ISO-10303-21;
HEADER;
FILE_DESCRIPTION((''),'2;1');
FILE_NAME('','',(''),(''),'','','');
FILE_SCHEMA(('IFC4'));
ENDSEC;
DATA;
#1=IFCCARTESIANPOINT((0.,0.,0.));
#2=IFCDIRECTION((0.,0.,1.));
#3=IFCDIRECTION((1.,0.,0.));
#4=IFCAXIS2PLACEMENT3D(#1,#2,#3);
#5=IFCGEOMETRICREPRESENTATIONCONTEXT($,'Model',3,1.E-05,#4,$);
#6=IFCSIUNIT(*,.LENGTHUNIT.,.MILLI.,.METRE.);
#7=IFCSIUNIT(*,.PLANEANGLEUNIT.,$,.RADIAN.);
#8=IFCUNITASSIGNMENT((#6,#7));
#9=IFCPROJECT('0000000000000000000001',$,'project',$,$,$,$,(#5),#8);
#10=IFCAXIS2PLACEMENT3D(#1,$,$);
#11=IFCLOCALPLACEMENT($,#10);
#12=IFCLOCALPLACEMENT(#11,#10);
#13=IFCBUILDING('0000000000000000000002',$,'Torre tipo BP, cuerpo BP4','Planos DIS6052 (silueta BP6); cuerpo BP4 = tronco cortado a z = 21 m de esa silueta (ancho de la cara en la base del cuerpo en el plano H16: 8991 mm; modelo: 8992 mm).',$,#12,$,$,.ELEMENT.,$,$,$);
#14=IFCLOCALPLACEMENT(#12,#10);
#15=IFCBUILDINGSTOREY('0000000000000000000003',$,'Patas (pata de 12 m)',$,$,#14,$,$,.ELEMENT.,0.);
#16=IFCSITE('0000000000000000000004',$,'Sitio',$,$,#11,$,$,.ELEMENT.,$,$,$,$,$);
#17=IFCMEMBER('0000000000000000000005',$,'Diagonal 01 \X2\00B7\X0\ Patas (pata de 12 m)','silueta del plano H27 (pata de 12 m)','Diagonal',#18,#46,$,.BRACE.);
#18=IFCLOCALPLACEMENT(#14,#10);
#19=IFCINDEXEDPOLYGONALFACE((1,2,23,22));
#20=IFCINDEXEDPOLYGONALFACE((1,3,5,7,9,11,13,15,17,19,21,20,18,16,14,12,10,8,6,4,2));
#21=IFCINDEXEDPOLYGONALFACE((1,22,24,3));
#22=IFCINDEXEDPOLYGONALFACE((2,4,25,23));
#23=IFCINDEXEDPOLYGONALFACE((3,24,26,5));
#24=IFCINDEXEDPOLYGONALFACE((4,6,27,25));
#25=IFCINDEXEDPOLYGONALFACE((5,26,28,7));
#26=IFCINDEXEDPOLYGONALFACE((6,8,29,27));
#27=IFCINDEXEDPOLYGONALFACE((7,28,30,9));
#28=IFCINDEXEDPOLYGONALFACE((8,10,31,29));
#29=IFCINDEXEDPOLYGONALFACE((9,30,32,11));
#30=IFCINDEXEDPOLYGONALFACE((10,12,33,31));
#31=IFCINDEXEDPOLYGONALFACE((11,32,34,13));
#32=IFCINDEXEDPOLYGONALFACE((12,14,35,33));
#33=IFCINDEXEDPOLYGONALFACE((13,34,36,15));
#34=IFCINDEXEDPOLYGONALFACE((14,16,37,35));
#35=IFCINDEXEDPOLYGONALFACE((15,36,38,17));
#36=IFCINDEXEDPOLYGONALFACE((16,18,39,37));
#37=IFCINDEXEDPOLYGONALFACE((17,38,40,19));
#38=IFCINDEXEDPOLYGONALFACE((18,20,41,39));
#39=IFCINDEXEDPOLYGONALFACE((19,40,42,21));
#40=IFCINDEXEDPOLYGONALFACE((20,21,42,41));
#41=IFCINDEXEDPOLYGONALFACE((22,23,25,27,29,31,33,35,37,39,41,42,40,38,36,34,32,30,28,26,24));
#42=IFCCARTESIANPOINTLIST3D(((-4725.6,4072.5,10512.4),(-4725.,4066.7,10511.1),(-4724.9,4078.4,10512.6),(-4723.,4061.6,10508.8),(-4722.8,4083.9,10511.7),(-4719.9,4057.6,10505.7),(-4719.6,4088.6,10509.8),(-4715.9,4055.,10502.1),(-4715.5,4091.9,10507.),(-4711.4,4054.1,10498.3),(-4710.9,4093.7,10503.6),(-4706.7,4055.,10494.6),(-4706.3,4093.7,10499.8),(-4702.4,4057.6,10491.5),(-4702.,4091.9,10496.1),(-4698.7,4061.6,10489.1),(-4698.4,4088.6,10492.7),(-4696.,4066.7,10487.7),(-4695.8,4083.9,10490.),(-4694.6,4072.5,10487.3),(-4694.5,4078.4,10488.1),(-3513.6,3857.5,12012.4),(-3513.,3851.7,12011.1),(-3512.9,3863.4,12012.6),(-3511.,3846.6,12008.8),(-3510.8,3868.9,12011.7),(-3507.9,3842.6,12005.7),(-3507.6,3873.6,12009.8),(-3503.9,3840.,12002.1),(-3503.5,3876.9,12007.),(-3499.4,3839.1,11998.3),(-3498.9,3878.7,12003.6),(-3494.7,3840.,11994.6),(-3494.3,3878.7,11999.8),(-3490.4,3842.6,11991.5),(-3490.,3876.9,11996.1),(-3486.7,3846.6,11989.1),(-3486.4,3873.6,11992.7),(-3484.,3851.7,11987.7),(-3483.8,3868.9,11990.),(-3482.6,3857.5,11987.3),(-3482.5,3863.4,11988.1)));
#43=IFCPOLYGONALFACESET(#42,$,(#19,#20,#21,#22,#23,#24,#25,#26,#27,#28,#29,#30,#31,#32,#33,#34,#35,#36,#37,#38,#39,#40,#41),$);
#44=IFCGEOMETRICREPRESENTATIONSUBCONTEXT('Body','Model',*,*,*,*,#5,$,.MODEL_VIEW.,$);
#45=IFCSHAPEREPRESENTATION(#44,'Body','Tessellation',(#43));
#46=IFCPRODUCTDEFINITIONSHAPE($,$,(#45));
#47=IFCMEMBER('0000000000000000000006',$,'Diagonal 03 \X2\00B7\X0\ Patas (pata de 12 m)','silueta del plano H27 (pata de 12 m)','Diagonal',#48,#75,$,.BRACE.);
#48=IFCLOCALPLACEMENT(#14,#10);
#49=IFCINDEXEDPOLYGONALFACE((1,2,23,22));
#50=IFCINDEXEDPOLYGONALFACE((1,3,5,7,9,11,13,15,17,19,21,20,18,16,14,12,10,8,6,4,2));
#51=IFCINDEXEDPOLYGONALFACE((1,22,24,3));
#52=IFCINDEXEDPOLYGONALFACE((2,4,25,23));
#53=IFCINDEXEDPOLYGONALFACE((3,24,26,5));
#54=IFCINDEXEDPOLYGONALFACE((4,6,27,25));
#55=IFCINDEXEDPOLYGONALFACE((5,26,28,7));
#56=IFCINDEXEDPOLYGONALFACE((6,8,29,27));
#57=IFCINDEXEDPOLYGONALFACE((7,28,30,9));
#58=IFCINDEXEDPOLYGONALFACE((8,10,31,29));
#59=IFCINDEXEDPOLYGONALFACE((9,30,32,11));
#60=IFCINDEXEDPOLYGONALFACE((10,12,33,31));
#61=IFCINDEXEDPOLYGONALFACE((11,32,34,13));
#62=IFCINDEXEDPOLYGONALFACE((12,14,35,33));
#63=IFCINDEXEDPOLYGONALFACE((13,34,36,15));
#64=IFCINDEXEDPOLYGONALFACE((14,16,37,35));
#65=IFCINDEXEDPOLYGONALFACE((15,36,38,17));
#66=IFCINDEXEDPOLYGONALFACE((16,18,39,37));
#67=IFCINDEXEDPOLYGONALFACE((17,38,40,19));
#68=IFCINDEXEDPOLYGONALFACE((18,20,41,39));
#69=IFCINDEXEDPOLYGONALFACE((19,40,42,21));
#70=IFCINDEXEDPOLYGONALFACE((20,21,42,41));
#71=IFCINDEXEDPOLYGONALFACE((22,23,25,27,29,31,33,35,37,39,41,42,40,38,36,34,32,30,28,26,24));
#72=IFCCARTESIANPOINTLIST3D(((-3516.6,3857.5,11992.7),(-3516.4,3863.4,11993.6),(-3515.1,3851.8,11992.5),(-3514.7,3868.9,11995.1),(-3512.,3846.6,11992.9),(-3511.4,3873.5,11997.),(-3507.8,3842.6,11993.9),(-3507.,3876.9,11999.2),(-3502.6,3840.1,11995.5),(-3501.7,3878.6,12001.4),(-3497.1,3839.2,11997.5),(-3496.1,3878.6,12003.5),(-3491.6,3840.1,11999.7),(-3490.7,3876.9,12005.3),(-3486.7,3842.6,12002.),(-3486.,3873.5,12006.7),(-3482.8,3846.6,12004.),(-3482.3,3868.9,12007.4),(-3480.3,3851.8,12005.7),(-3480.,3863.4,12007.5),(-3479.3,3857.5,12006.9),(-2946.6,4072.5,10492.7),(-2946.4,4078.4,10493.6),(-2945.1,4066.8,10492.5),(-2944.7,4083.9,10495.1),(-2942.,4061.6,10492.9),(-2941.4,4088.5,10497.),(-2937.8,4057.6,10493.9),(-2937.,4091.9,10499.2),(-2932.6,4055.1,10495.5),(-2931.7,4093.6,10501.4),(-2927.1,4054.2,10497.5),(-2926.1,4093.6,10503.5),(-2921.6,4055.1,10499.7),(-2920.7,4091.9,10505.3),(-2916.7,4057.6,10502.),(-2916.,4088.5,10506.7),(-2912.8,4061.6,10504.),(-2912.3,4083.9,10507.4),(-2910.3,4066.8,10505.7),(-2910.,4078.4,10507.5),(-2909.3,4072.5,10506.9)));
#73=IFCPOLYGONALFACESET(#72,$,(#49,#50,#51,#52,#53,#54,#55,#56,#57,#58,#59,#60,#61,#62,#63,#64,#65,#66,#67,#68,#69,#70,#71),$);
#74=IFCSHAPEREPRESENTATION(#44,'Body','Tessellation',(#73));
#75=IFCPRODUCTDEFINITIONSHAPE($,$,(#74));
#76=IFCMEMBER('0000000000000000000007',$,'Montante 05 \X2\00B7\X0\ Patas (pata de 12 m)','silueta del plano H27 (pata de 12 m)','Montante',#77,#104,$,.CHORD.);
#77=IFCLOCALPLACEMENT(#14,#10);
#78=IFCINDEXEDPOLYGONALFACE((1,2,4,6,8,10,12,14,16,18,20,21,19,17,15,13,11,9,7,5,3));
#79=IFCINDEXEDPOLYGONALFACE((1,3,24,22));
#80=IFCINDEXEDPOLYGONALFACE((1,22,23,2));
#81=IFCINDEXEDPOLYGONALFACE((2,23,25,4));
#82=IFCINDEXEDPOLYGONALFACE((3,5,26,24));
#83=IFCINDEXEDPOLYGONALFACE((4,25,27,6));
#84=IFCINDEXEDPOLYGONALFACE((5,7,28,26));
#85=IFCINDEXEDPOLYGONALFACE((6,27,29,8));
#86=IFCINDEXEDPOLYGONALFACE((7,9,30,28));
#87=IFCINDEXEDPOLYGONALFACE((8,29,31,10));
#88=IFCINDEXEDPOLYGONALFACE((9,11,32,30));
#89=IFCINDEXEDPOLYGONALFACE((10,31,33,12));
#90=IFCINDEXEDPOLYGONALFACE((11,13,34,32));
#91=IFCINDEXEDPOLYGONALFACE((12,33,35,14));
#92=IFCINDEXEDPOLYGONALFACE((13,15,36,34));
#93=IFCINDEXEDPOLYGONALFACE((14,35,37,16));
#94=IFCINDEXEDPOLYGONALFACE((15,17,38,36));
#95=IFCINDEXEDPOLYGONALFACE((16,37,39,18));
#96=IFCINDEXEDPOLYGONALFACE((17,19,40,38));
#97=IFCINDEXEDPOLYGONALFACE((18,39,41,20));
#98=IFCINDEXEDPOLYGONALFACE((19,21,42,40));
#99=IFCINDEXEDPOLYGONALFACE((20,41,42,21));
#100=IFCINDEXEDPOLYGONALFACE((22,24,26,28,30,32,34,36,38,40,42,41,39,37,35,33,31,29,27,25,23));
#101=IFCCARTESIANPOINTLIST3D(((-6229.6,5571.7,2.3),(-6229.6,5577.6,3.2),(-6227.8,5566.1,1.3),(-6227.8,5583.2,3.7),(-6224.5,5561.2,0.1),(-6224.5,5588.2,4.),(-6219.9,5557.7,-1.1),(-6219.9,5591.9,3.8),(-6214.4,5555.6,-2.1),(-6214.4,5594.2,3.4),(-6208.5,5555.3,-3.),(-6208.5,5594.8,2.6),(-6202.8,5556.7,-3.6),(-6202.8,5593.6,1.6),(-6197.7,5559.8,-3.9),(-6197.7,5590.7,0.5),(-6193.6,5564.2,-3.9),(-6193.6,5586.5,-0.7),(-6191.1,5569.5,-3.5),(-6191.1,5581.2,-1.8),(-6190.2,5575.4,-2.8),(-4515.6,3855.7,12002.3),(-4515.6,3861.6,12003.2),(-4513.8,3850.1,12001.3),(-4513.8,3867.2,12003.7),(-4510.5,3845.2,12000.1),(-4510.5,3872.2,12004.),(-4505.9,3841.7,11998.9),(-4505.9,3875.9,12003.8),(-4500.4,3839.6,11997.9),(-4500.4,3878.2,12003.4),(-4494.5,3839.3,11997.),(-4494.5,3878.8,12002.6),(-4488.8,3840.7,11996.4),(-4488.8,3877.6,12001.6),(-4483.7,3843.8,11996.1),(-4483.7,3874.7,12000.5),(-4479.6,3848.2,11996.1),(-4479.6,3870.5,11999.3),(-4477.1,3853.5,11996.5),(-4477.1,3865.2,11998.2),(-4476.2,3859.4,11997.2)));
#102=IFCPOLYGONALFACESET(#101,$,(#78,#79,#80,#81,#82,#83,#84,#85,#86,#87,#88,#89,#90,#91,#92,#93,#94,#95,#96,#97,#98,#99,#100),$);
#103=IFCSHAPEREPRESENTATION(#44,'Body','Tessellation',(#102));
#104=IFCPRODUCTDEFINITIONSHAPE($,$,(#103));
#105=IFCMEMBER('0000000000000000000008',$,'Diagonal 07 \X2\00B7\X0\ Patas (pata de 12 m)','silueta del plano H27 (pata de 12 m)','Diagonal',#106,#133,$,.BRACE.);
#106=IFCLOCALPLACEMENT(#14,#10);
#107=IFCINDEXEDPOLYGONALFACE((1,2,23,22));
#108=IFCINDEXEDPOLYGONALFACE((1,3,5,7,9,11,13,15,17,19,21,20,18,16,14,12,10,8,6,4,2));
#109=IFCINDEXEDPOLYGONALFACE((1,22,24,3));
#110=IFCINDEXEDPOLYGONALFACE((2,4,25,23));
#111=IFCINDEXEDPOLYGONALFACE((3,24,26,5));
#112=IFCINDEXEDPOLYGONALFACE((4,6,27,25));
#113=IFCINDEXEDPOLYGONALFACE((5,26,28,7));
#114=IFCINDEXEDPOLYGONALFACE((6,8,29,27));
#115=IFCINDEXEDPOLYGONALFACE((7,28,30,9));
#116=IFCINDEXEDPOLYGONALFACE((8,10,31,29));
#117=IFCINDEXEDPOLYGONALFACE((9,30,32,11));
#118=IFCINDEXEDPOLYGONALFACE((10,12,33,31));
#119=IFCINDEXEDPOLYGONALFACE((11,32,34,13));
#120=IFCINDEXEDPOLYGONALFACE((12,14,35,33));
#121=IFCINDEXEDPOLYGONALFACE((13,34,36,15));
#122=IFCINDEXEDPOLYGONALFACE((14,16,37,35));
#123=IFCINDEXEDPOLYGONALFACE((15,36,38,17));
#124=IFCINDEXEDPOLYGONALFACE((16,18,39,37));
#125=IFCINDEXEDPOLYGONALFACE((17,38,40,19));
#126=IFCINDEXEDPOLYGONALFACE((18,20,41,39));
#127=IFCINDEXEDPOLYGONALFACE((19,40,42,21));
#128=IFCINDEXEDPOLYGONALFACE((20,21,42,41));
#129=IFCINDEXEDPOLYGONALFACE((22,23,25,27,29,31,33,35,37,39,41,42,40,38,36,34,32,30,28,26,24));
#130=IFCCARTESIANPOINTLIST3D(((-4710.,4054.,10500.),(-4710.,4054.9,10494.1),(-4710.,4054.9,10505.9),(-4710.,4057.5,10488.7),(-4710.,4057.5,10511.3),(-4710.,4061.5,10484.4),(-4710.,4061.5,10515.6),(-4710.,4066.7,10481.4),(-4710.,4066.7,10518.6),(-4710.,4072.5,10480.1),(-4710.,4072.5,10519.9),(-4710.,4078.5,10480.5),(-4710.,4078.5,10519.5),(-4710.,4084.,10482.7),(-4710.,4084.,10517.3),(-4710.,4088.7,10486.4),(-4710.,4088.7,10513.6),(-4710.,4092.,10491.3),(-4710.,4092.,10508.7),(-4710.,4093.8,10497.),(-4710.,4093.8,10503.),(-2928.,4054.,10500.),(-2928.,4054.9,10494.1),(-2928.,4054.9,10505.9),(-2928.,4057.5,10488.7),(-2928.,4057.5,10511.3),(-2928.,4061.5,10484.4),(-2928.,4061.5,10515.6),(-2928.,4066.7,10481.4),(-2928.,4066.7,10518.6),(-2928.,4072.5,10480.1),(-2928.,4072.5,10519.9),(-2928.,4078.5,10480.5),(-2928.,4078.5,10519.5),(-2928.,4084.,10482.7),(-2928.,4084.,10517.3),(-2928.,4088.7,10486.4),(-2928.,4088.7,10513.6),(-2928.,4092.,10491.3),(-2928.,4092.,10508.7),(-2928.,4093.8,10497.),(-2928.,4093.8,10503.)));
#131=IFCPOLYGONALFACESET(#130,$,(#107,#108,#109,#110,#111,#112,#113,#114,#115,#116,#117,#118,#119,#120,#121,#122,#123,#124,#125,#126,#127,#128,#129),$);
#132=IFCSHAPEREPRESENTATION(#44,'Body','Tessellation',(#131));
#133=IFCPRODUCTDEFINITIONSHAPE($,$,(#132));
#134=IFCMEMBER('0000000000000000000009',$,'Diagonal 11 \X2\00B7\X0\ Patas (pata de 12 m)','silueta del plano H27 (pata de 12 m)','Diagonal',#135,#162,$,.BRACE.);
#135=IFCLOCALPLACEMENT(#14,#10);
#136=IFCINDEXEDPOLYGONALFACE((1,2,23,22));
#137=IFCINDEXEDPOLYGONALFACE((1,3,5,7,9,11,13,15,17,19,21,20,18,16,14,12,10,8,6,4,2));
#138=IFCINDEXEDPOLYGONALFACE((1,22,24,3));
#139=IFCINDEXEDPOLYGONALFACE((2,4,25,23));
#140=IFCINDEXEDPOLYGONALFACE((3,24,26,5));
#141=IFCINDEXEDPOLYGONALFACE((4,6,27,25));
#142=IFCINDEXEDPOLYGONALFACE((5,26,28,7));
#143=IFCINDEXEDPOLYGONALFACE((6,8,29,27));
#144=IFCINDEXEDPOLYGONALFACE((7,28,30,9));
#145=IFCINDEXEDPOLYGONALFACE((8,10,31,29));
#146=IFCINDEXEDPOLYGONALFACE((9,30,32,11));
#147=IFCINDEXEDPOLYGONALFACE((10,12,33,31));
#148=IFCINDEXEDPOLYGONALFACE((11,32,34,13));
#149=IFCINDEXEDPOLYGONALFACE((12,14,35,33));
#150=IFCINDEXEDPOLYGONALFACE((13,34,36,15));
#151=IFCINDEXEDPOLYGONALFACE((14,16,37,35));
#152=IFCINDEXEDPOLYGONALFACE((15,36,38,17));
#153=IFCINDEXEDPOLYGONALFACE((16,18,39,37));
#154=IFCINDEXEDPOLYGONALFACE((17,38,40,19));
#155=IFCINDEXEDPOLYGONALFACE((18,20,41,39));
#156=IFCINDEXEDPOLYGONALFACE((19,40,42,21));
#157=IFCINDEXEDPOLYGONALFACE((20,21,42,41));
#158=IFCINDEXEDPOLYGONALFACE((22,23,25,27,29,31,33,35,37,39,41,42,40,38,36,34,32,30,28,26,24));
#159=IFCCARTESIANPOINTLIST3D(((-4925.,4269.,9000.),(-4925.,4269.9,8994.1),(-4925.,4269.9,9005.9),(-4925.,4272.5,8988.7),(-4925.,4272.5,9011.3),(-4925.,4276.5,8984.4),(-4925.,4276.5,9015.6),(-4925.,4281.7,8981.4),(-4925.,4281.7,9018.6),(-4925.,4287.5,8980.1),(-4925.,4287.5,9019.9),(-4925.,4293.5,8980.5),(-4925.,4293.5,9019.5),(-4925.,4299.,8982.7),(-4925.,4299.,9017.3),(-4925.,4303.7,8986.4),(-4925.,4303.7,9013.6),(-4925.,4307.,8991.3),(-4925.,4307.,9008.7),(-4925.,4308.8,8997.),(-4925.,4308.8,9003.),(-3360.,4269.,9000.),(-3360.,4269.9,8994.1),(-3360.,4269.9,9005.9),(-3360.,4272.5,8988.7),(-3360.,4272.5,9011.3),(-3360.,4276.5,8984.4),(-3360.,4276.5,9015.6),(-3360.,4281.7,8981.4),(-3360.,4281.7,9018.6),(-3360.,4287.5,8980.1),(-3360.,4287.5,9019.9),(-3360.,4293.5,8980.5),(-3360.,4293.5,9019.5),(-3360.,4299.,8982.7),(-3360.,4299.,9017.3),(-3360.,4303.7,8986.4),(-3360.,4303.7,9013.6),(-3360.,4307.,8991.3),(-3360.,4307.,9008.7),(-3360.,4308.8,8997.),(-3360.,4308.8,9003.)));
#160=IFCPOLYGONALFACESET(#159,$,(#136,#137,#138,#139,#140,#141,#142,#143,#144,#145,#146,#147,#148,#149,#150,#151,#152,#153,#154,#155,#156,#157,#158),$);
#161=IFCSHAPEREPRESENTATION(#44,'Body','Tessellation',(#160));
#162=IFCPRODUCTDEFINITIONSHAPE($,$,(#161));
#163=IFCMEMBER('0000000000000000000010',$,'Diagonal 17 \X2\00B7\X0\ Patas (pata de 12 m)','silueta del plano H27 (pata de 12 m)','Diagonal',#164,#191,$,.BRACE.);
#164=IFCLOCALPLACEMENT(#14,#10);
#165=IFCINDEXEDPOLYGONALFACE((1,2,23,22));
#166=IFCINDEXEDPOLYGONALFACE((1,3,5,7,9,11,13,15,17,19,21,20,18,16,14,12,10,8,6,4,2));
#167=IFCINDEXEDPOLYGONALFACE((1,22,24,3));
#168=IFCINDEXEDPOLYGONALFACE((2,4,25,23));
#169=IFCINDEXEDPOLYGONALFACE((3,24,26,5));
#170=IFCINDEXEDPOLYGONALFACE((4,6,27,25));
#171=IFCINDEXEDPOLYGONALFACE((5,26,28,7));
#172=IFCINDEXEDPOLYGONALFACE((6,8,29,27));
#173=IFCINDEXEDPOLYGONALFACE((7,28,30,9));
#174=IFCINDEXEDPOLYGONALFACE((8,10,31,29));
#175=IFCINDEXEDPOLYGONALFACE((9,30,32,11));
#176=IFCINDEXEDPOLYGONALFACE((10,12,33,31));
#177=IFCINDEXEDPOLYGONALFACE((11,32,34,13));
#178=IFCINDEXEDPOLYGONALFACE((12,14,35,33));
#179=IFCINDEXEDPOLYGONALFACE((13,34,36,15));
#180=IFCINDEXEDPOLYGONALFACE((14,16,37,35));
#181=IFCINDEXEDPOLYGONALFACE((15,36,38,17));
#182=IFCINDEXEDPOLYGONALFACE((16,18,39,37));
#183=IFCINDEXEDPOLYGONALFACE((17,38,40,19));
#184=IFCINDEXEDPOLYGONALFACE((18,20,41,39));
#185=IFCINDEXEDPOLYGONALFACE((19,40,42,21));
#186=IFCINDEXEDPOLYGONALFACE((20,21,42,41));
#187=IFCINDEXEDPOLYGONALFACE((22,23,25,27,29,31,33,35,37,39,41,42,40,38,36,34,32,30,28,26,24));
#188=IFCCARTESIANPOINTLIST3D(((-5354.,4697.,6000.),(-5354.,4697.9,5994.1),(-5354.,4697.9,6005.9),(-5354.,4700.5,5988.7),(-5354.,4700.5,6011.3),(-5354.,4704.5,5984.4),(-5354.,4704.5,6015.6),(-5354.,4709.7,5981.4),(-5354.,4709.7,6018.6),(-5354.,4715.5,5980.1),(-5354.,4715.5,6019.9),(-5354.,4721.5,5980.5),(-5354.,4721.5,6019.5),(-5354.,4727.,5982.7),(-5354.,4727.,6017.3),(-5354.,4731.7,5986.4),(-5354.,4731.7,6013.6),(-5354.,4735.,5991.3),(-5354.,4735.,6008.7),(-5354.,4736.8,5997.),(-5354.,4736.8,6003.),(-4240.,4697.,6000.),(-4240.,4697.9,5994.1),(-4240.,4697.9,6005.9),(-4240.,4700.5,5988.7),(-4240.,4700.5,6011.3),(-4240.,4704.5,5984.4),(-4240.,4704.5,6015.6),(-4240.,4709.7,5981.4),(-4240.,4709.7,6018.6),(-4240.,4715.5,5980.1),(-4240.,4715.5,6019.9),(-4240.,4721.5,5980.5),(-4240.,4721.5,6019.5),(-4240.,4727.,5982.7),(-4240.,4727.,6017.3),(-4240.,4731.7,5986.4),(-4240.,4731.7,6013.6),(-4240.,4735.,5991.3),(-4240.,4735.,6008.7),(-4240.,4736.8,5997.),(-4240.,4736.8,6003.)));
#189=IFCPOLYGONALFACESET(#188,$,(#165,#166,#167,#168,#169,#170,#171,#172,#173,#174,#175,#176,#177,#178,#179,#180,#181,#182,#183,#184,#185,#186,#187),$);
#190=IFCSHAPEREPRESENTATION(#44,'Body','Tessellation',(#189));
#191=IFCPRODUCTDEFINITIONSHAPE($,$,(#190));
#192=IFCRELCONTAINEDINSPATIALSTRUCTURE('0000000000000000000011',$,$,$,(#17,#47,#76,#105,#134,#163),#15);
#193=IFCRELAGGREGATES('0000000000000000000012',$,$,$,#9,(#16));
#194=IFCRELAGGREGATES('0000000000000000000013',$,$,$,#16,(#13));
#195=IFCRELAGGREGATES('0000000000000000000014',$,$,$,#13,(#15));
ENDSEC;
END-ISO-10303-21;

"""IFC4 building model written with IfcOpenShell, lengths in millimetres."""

from ifc_helpers import new_model, si_unit, frame, origin, origin_with_axes, place, context, subcontext, project, spatial, circle, extrude, element, save


model = new_model("IFC4")

# Units and contexts
model_context = context("Model", 3, precision=1e-05, world=origin_with_axes())
body_context = subcontext(model_context, "Body", "Model", "MODEL_VIEW")
ifc_project = project(units=[si_unit("LENGTHUNIT", "METRE", prefix="MILLI"), si_unit("PLANEANGLEUNIT", "RADIAN")], contexts=[model_context])

# Site, building, storey
site_placement = place(None, origin())
site = spatial("IfcSite", under=ifc_project, at=site_placement, Name="Sitio", CompositionType="ELEMENT")
building_placement = place(site_placement, origin())
building = spatial("IfcBuilding", under=site, at=building_placement, Name="Torre tipo BP, cuerpo BP4", Description="Planos DIS6052 (silueta BP6); cuerpo BP4 = tronco cortado a z = 21 m de esa silueta (ancho de la cara en la base del cuerpo en el plano H16: 8991 mm; modelo: 8992 mm).", CompositionType="ELEMENT")
storey_placement = place(building_placement, origin())
storey = spatial("IfcBuildingStorey", under=building, at=storey_placement, Name="Patas (pata de 12 m)", CompositionType="ELEMENT", Elevation=0.0)

# Members
member_1_placement = place(storey_placement, frame((-4710.0, 4074.0, 10500.0), z_axis=(0.624612, -0.110802, 0.773035), x_axis=(-0.069637, -0.993843, -0.086184)))
element("IfcMember", 1, at=member_1_placement, inside=storey, Name="Diagonal 01 · Patas (pata de 12 m)", Description="silueta del plano H27 (pata de 12 m)", ObjectType="Diagonal", PredefinedType="BRACE", context=body_context, shape_type="SweptSolid", body=[
    extrude(circle(Radius=20.0), None, (0.0, 0.0, 1.0), 1940.4),
])
member_2_placement = place(storey_placement, frame((-3498.0, 3859.0, 12000.0), z_axis=(0.352072, 0.132799, -0.926504), x_axis=(0.047173, -0.991143, -0.124138)))
element("IfcMember", 2, at=member_2_placement, inside=storey, Name="Diagonal 03 · Patas (pata de 12 m)", Description="silueta del plano H27 (pata de 12 m)", ObjectType="Diagonal", PredefinedType="BRACE", context=body_context, shape_type="SweptSolid", body=[
    extrude(circle(Radius=20.0), None, (0.0, 0.0, 1.0), 1619.0),
])
member_3_placement = place(storey_placement, frame((-4496.0, 3859.0, 12000.0), z_axis=(-0.140002, 0.140166, -0.98018), x_axis=(0.990151, 0.019819, -0.138593)))
element("IfcMember", 3, at=member_3_placement, inside=storey, Name="Montante 05 · Patas (pata de 12 m)", Description="silueta del plano H27 (pata de 12 m)", ObjectType="Montante", PredefinedType="CHORD", context=body_context, shape_type="SweptSolid", body=[
    extrude(circle(Radius=20.0), None, (0.0, 0.0, 1.0), 12242.6),
])
member_4_placement = place(storey_placement, frame((-2928.0, 4074.0, 10500.0), z_axis=(-1.0, 0.0, 0.0), x_axis=(0.0, -1.0, 0.0)))
element("IfcMember", 4, at=member_4_placement, inside=storey, Name="Diagonal 07 · Patas (pata de 12 m)", Description="silueta del plano H27 (pata de 12 m)", ObjectType="Diagonal", PredefinedType="BRACE", context=body_context, shape_type="SweptSolid", body=[
    extrude(circle(Radius=20.0), None, (0.0, 0.0, 1.0), 1782.0),
])
member_5_placement = place(storey_placement, frame((-4925.0, 4289.0, 9000.0), z_axis=(1.0, 0.0, 0.0), x_axis=(0.0, -1.0, 0.0)))
element("IfcMember", 5, at=member_5_placement, inside=storey, Name="Diagonal 11 · Patas (pata de 12 m)", Description="silueta del plano H27 (pata de 12 m)", ObjectType="Diagonal", PredefinedType="BRACE", context=body_context, shape_type="SweptSolid", body=[
    extrude(circle(Radius=20.0), None, (0.0, 0.0, 1.0), 1565.0),
])
member_6_placement = place(storey_placement, frame((-5354.0, 4717.0, 6000.0), z_axis=(1.0, 0.0, 0.0), x_axis=(0.0, -1.0, 0.0)))
element("IfcMember", 6, at=member_6_placement, inside=storey, Name="Diagonal 17 · Patas (pata de 12 m)", Description="silueta del plano H27 (pata de 12 m)", ObjectType="Diagonal", PredefinedType="BRACE", context=body_context, shape_type="SweptSolid", body=[
    extrude(circle(Radius=20.0), None, (0.0, 0.0, 1.0), 1114.0),
])

save(model, "model.ifc")
